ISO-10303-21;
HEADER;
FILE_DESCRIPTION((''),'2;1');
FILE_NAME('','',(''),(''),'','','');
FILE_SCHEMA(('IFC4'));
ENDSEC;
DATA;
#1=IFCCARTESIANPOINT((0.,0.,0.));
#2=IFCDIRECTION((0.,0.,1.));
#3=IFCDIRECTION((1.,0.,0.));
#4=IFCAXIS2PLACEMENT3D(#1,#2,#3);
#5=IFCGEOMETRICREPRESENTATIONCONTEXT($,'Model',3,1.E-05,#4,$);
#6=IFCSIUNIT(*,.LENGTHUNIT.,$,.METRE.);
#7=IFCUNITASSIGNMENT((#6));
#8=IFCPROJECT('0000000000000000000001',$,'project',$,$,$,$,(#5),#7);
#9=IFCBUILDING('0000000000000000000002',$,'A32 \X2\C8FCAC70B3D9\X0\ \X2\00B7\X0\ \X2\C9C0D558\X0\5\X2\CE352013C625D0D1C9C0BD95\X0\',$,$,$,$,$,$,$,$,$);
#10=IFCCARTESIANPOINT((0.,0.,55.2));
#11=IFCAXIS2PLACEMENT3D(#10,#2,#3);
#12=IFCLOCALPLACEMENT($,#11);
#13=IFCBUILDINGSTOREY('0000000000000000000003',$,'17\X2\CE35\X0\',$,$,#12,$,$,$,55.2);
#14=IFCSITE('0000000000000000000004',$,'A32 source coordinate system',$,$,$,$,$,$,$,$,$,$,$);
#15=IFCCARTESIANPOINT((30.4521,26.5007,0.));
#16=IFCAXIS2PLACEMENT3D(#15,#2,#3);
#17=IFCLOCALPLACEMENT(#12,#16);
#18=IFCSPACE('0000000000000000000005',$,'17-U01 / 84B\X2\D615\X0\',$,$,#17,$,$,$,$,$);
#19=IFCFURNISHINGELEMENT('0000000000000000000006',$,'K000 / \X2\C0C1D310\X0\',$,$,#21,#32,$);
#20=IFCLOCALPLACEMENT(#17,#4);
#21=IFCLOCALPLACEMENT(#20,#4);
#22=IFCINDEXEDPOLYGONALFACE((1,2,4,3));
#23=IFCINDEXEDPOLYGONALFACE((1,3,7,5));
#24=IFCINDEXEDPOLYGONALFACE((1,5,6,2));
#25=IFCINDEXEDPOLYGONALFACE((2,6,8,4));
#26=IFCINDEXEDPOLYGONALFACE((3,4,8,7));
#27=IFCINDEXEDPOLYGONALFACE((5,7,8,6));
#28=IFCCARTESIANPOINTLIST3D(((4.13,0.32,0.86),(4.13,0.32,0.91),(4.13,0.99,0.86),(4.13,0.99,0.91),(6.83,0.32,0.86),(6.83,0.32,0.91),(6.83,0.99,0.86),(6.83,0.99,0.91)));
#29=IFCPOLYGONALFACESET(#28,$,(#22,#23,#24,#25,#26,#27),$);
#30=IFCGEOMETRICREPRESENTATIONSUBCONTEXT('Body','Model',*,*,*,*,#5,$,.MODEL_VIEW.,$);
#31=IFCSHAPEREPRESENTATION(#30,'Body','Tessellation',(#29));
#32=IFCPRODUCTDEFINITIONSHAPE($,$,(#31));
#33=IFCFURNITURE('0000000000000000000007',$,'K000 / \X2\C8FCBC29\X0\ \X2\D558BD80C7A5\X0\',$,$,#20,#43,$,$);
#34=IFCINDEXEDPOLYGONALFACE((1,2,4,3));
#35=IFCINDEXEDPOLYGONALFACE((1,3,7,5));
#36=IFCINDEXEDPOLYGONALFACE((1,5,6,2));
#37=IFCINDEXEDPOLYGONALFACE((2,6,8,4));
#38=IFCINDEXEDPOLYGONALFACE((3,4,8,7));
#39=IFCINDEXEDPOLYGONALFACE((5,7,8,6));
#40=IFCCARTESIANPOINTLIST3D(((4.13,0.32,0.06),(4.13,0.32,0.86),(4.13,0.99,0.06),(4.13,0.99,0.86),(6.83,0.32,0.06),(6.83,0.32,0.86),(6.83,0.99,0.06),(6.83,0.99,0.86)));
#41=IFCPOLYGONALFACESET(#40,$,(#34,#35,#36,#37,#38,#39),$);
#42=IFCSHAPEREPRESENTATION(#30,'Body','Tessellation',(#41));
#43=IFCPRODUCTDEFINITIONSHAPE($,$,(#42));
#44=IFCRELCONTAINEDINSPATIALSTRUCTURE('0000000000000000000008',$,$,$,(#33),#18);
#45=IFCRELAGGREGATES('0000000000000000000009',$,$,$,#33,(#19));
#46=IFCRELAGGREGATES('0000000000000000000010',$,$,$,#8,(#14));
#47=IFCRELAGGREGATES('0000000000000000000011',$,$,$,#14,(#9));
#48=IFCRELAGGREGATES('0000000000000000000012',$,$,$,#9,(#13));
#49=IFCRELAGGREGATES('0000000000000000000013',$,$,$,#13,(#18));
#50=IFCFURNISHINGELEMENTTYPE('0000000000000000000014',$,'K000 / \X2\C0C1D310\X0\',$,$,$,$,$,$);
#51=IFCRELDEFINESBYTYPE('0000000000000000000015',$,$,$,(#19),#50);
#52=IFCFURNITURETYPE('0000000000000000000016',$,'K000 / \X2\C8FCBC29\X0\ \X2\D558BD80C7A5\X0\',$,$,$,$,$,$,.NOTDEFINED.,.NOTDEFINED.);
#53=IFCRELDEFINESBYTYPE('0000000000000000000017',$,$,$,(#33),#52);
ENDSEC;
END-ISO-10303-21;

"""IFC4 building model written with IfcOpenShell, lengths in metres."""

from ifc_helpers import new_model, si_unit, frame, origin, origin_with_axes, place, context, subcontext, project, spatial, polyline, outline, extrude, source, transform, mapped, type_object, type_shapes, element, aggregate, save


model = new_model("IFC4")

# Units and contexts
model_context = context("Model", 3, precision=1e-05, world=origin_with_axes())
body_context = subcontext(model_context, "Body", "Model", "MODEL_VIEW")
ifc_project = project(units=[si_unit("LENGTHUNIT", "METRE")], contexts=[model_context])

# Site, building, storey, space
site = spatial("IfcSite", under=ifc_project, Name="A32 source coordinate system")
building = spatial("IfcBuilding", under=site, Name="A32 주거동 · 지하5층–옥탑지붕")
storey_placement = place(None, frame((0.0, 0.0, 55.2), z_axis=(0.0, 0.0, 1.0), x_axis=(1.0, 0.0, 0.0)))
storey = spatial("IfcBuildingStorey", under=building, at=storey_placement, Name="17층", Elevation=55.2)
space_placement = place(storey_placement, frame((30.4521, 26.5007, 0.0), z_axis=(0.0, 0.0, 1.0), x_axis=(1.0, 0.0, 0.0)))
space = spatial("IfcSpace", under=storey, at=space_placement, Name="17-U01 / 84B형")

# Furnishing element
furnishing_element_type = type_object("IfcFurnishingElementType", Name="K000 / 상판")
shared_shape_1 = source(origin(), body_context, "Body", "SweptSolid", [
    extrude(outline(polyline([(4.13, 0.32), (4.13, 0.99), (6.83, 0.99), (6.83, 0.32), (4.13, 0.32)])), frame((0.0, 0.0, 0.86)), (0.0, 0.0, 1.0), 0.05),
])
type_shapes(furnishing_element_type, [shared_shape_1])
furniture_placement = place(space_placement, origin_with_axes())
furnishing_placement = place(furniture_placement, origin_with_axes())
furnishing = element("IfcFurnishingElement", 1, at=furnishing_placement, type_object=furnishing_element_type, Name="K000 / 상판", context=body_context, shape_type="MappedRepresentation", body=[
    mapped(shared_shape_1, transform((0.0, 0.0, 0.0), scale=1.0)),
])

# Furniture
furniture_type = type_object("IfcFurnitureType", Name="K000 / 주방 하부장", AssemblyPlace="NOTDEFINED", PredefinedType="NOTDEFINED")
shared_shape_2 = source(origin(), body_context, "Body", "SweptSolid", [
    extrude(outline(polyline([(6.83, 0.32), (4.13, 0.32), (4.13, 0.99), (6.83, 0.99), (6.83, 0.32)])), frame((0.0, 0.0, 0.06)), (0.0, 0.0, 1.0), 0.8),
])
type_shapes(furniture_type, [shared_shape_2])
furniture = element("IfcFurniture", 2, at=furniture_placement, inside=space, type_object=furniture_type, Name="K000 / 주방 하부장", context=body_context, shape_type="MappedRepresentation", body=[
    mapped(shared_shape_2, transform((0.0, 0.0, 0.0), scale=1.0)),
])
aggregate(furniture, [furnishing])

save(model, "model.ifc")
